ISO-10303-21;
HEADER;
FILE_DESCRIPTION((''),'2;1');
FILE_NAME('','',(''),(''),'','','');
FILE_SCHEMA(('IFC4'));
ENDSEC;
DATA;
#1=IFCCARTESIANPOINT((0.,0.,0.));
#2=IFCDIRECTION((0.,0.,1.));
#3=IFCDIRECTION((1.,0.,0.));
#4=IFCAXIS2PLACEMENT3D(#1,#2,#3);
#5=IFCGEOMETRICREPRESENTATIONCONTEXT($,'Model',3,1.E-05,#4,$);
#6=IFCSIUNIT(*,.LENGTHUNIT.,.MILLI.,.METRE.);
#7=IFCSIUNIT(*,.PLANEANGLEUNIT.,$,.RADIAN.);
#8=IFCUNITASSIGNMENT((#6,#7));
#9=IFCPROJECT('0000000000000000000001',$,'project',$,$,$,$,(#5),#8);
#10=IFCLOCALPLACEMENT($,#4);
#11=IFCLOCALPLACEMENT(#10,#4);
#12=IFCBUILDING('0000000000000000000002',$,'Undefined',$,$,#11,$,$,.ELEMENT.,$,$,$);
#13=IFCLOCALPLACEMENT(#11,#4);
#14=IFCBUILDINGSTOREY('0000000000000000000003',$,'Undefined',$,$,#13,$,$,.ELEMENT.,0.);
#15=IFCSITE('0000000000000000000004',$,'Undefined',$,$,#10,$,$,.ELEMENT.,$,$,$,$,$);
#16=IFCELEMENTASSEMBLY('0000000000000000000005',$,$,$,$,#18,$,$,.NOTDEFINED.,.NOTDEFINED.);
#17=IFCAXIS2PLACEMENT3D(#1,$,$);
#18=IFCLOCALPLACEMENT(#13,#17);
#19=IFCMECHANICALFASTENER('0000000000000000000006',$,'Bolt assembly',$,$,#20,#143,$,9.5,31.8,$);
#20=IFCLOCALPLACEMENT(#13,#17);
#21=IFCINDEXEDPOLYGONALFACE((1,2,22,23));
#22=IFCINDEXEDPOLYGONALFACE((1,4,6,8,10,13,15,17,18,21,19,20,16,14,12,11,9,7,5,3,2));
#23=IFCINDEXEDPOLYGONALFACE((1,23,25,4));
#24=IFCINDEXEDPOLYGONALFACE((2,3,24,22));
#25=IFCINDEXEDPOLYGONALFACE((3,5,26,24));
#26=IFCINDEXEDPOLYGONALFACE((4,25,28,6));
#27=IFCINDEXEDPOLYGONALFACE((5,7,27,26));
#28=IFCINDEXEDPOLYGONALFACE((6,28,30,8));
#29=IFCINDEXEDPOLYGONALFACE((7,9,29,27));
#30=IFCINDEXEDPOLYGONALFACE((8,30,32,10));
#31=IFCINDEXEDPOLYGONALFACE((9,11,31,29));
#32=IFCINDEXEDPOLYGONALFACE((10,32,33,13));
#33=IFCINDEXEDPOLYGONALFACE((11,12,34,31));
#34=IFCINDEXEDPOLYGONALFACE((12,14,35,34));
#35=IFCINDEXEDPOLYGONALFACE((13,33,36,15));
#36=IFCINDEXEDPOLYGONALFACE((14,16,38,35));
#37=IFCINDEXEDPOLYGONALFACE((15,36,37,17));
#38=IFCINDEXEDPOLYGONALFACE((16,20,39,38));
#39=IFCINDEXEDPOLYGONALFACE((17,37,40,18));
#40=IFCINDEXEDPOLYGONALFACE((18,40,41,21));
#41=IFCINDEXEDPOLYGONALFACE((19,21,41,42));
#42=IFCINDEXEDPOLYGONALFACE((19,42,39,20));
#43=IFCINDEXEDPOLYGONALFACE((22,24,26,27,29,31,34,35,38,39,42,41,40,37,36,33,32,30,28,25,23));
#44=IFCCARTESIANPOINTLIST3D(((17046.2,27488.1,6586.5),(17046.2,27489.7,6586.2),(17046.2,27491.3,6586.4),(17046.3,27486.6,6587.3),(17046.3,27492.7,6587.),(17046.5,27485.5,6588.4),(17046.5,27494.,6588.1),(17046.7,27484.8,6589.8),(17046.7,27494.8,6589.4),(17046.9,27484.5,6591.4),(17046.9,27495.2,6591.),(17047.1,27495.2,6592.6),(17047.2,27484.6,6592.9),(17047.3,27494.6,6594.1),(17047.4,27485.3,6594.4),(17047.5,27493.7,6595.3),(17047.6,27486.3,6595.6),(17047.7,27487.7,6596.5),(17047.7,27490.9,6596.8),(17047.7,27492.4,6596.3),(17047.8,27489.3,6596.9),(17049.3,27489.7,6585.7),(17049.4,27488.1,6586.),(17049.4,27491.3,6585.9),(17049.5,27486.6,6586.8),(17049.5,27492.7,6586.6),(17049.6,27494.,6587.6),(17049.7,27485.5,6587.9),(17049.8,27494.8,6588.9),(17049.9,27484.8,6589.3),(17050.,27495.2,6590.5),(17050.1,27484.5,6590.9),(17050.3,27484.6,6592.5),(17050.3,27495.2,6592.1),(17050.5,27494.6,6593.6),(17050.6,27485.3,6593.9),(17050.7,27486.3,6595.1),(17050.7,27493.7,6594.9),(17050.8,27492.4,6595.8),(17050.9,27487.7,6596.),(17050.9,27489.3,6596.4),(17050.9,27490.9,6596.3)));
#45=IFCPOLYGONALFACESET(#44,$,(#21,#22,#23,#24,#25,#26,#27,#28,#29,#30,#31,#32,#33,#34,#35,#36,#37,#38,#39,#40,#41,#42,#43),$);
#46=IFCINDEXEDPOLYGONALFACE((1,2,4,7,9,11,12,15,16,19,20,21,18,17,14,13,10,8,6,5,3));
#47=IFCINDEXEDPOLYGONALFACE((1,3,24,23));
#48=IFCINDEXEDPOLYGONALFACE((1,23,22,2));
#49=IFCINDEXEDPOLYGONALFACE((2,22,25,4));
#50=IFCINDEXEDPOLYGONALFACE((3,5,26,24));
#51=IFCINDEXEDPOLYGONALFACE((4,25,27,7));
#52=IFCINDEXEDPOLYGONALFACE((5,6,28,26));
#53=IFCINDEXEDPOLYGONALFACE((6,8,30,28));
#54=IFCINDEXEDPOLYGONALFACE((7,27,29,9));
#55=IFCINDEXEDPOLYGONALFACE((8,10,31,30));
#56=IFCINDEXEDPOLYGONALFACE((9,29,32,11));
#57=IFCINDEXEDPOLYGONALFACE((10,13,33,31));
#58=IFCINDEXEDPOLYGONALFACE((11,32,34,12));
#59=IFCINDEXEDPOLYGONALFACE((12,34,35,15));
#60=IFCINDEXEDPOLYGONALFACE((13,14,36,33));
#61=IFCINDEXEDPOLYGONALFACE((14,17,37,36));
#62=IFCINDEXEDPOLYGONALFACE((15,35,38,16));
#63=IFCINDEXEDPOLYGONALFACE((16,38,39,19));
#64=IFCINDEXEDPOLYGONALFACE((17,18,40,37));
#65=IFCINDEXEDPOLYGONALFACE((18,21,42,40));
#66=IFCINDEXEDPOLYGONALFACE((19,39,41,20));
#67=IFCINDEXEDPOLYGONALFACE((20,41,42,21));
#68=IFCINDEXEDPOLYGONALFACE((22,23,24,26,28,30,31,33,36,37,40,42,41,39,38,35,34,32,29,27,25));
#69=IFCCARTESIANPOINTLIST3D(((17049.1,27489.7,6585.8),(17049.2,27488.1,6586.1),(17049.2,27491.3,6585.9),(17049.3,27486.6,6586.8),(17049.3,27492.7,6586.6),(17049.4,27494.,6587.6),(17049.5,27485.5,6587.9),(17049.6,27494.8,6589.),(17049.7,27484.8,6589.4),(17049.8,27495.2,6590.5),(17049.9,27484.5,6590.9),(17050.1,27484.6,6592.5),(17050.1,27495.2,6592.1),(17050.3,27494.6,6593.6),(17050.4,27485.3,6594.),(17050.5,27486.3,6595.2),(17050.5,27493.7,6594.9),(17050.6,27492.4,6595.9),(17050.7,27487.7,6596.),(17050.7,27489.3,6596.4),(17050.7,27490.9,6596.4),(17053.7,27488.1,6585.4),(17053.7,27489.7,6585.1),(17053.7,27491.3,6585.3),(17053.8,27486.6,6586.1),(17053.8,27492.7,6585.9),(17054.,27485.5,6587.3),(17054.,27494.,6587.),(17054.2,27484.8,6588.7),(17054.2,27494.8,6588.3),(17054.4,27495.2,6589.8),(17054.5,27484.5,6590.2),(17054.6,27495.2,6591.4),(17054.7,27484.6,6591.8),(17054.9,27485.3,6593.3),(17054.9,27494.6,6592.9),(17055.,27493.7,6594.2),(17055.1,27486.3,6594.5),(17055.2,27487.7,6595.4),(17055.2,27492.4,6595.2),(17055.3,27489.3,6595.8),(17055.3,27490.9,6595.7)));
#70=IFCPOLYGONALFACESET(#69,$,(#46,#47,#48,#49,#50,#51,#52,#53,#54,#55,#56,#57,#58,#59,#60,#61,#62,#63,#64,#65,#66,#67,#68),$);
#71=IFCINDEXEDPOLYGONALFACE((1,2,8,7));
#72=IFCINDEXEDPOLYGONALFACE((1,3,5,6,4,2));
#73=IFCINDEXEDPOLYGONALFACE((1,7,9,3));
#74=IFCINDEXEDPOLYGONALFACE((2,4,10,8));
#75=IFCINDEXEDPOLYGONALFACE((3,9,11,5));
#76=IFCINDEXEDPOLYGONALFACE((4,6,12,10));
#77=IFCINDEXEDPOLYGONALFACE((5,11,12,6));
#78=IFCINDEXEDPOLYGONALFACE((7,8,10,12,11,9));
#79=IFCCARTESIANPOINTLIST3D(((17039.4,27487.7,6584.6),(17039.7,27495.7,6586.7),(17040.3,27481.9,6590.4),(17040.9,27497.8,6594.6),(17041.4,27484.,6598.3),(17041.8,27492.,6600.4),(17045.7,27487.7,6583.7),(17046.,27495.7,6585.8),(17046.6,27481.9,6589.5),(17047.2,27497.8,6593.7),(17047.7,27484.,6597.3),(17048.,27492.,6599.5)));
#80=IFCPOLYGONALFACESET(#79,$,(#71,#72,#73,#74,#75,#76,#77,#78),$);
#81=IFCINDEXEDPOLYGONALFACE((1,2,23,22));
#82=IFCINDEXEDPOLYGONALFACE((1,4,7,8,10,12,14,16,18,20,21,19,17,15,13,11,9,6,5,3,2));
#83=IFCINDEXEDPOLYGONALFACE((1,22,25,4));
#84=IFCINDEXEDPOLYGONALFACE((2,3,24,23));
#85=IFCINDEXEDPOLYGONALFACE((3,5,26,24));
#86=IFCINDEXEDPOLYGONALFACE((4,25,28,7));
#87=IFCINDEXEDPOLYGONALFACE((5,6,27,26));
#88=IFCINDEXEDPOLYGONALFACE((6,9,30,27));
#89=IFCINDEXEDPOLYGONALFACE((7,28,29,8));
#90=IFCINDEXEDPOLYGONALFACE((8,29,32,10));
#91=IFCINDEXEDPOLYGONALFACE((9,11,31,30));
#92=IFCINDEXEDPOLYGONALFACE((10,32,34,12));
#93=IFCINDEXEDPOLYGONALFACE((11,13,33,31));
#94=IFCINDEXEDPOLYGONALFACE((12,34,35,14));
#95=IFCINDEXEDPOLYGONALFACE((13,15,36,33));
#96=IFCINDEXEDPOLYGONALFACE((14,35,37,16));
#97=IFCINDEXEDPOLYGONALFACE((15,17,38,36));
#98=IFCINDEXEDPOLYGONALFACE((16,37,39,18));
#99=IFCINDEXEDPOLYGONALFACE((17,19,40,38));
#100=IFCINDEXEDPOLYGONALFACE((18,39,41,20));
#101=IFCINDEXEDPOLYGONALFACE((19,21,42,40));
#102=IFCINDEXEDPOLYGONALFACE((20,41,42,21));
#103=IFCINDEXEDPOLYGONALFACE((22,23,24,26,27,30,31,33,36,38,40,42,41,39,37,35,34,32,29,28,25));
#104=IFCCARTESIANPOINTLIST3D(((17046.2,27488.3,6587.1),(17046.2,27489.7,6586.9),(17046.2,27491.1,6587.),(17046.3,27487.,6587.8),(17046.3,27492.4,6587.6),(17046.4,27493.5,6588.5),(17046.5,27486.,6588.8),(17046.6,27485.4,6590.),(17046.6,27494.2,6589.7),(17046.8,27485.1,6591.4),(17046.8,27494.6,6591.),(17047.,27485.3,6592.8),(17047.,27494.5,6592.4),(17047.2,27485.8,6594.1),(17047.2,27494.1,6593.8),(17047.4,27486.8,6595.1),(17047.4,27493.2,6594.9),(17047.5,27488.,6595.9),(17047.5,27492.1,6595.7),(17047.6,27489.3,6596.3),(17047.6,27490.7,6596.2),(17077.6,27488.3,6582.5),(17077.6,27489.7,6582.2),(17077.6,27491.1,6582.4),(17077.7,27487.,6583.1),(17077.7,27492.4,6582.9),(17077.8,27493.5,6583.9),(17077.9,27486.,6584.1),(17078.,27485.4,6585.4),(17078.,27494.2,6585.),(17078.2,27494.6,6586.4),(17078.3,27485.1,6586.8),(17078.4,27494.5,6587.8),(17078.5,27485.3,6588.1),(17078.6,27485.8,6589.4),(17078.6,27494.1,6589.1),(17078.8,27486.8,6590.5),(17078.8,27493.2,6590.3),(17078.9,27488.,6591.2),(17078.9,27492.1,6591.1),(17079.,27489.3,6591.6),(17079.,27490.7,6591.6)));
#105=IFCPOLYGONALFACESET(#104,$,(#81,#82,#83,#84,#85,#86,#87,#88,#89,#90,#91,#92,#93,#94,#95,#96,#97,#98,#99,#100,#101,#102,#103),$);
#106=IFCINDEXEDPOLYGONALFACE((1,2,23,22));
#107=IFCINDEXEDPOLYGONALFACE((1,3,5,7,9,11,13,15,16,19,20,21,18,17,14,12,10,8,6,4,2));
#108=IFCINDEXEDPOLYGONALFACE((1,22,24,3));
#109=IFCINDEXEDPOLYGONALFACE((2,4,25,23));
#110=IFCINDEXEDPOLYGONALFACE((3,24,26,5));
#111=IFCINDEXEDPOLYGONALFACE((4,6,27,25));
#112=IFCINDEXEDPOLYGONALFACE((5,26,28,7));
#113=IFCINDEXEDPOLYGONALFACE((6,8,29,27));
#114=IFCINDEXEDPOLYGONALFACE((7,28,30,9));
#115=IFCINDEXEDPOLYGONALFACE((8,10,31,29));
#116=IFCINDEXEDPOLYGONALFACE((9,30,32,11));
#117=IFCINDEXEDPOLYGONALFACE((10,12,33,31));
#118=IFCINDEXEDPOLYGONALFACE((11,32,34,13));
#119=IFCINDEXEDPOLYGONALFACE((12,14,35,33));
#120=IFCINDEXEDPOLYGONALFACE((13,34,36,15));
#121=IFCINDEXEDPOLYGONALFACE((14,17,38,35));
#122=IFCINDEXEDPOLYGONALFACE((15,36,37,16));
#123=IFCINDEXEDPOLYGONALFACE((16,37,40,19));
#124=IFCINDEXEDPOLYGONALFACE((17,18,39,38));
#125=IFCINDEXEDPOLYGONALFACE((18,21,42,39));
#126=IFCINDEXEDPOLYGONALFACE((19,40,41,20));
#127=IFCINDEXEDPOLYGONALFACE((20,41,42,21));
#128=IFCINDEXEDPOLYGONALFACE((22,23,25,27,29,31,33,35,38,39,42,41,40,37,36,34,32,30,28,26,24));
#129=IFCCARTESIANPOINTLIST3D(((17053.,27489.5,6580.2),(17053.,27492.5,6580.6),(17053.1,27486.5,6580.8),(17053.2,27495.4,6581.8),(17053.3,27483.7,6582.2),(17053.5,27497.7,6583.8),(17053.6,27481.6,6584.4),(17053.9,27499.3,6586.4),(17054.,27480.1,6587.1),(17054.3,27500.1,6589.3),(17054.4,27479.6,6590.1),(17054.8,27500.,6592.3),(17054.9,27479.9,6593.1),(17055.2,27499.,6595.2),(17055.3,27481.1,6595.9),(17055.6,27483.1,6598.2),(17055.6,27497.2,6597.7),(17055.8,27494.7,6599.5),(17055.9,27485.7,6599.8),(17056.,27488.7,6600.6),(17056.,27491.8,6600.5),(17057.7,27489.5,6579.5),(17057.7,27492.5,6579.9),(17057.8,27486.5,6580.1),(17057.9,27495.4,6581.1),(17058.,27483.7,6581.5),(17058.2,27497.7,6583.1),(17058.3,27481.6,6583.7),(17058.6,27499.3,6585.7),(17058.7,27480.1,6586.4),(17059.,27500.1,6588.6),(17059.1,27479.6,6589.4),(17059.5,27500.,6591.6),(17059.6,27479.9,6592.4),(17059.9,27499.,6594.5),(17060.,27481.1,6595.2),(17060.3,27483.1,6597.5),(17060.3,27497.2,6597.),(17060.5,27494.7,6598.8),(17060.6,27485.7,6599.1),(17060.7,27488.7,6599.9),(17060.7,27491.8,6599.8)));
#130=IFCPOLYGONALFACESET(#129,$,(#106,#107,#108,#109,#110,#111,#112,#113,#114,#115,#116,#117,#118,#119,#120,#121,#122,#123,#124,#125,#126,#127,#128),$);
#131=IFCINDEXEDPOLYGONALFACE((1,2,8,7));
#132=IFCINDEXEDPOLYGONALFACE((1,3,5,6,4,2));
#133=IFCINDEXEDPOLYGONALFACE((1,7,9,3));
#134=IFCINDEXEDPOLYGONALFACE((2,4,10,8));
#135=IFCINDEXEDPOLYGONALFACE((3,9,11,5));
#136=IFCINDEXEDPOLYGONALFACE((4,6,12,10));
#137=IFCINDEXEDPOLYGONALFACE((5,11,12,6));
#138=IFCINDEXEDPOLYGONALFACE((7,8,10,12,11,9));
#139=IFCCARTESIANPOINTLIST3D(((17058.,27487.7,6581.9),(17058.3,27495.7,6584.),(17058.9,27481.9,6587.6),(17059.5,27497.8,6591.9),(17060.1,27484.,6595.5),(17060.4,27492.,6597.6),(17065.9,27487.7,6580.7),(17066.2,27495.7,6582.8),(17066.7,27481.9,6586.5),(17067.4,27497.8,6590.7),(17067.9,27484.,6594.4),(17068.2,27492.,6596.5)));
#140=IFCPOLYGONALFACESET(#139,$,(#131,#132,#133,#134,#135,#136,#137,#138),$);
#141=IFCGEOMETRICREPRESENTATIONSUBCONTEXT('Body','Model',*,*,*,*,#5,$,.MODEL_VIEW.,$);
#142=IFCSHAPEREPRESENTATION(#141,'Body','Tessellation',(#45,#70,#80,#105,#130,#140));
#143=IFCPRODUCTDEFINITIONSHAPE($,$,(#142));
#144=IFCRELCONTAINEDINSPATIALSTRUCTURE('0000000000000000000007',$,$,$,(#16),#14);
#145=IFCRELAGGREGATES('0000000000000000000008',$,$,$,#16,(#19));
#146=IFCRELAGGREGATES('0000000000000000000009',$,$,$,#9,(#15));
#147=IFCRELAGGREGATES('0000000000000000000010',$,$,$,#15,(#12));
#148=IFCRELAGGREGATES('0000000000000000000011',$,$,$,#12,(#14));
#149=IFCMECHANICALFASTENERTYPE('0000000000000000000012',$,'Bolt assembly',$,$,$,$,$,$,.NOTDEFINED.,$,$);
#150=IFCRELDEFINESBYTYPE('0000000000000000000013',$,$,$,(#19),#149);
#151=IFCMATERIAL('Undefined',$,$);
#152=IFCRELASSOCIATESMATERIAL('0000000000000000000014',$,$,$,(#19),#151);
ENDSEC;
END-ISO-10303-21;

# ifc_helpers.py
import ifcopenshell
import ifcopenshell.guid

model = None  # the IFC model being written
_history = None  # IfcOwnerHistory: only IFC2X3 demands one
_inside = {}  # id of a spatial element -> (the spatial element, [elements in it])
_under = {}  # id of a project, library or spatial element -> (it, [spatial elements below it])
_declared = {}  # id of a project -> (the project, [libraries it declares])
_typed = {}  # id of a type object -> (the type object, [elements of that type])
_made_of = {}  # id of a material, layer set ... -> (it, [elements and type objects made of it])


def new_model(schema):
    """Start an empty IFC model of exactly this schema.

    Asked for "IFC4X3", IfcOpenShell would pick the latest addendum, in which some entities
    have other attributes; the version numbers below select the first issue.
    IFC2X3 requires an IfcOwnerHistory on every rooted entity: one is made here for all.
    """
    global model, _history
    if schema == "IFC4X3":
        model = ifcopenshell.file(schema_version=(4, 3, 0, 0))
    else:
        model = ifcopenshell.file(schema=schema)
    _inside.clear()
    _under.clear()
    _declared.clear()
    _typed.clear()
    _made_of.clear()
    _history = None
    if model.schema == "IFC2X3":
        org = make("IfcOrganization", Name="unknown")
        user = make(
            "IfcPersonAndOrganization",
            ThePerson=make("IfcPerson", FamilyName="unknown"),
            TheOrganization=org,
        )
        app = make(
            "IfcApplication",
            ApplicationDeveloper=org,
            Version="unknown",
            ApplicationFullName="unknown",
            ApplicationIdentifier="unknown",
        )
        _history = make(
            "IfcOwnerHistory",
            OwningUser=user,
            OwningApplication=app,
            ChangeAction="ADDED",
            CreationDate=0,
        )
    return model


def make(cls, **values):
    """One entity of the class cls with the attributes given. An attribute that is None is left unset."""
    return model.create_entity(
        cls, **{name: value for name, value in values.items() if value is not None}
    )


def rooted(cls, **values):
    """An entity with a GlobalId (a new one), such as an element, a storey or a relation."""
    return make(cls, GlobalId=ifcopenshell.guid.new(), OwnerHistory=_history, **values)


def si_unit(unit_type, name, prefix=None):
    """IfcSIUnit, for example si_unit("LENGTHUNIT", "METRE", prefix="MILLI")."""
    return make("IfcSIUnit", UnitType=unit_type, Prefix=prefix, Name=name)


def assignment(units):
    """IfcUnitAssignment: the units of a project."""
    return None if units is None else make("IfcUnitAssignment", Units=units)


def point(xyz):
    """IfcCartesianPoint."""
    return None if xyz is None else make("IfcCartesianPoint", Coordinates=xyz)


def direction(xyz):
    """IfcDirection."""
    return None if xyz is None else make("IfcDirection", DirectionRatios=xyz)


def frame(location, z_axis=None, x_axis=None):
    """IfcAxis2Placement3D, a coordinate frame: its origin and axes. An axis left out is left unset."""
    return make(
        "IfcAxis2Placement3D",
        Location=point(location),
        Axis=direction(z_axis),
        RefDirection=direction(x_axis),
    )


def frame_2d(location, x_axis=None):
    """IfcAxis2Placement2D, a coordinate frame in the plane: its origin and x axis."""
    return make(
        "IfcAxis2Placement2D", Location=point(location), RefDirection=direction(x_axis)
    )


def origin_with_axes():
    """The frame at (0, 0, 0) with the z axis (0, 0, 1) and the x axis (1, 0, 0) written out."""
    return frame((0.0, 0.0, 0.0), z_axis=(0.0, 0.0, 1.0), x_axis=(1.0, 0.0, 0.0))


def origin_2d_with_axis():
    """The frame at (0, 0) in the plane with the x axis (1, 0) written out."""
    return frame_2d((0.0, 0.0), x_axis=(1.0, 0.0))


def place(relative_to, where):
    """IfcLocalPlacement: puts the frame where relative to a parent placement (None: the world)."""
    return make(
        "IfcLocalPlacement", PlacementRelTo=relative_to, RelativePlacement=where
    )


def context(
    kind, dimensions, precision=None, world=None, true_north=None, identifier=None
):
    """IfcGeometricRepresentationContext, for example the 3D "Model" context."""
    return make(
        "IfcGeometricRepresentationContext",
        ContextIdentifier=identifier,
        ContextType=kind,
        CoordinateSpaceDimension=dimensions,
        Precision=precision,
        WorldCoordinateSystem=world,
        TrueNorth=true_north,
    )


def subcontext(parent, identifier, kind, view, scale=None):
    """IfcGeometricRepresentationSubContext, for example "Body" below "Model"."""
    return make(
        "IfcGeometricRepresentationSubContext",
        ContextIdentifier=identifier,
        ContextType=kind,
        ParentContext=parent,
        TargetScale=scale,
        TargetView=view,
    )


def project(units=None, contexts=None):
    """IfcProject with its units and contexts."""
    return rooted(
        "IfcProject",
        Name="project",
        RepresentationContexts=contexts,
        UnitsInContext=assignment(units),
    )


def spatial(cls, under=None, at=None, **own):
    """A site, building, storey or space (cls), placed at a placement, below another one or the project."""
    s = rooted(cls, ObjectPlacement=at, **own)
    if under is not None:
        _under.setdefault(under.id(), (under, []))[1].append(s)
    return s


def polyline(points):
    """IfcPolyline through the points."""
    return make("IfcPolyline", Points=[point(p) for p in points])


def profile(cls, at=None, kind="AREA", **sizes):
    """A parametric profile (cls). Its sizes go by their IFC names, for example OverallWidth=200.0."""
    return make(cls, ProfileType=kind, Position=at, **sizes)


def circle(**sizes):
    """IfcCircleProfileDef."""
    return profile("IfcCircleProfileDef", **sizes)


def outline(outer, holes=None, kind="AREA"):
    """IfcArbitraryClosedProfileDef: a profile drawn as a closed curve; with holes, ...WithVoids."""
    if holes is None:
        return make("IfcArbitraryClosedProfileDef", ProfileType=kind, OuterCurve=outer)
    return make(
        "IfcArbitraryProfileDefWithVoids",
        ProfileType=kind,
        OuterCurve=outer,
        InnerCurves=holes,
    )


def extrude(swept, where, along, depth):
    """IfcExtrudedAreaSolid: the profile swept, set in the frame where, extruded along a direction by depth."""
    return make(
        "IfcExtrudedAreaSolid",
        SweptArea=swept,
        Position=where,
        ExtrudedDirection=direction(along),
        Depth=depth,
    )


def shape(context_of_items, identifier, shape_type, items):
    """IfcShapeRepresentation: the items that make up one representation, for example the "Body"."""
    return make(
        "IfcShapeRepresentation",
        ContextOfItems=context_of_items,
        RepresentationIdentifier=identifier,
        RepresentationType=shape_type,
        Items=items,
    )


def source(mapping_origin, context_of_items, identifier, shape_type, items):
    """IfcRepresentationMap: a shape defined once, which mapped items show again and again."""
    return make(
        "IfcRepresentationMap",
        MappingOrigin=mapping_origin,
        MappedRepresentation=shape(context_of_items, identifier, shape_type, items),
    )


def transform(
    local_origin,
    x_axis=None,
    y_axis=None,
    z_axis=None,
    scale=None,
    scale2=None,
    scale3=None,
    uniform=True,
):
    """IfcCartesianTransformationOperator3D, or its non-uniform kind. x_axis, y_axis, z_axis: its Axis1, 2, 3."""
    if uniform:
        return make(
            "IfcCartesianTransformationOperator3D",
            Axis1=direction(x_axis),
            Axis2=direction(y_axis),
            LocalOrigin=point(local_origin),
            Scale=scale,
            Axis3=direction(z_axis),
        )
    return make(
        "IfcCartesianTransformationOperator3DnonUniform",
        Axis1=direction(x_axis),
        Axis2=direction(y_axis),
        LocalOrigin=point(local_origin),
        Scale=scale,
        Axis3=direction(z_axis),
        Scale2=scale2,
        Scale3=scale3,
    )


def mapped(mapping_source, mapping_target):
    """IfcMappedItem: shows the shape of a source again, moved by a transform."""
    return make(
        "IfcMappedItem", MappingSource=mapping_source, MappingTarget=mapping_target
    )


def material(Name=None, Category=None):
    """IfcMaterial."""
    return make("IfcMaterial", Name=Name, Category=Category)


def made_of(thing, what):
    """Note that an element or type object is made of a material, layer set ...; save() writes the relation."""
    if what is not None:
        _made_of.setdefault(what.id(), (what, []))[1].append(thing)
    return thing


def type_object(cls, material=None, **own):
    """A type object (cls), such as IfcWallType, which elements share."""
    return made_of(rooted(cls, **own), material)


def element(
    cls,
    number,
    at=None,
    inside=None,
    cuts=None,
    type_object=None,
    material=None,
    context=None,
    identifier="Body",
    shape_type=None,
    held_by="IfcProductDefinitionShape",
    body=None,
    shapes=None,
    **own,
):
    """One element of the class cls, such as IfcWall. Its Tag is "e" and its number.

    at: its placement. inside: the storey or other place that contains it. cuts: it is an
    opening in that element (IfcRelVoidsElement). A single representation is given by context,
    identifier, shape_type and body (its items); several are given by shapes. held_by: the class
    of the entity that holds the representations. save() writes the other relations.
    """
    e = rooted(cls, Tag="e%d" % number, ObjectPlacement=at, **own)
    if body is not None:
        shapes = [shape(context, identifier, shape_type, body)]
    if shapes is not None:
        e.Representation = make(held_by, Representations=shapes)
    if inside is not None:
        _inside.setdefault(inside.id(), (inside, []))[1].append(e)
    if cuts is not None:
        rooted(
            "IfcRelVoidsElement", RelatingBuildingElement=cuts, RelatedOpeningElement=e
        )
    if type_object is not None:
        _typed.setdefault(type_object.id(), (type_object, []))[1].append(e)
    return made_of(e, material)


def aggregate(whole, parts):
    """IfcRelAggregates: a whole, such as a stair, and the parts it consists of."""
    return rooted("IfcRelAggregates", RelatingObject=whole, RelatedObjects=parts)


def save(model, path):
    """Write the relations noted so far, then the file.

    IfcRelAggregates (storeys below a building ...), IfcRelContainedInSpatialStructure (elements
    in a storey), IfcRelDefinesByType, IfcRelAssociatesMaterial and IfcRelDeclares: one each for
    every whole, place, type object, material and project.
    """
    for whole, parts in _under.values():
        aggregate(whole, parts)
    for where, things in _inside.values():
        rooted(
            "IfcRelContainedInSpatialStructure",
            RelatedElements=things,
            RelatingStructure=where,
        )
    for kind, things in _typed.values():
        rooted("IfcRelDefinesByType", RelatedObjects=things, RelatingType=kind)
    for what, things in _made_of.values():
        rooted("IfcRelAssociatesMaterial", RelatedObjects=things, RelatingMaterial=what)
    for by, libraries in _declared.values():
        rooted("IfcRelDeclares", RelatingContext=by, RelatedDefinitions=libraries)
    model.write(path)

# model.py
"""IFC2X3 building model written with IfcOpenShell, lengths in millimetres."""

from ifc_helpers import new_model, si_unit, frame, origin_with_axes, origin_2d_with_axis, place, context, subcontext, project, spatial, polyline, circle, outline, extrude, source, transform, mapped, material, type_object, element, aggregate, save


model = new_model("IFC2X3")

# Units and contexts
model_context = context("Model", 3, precision=1e-05, world=origin_with_axes())
body_context = subcontext(model_context, "Body", "Model", "MODEL_VIEW")
ifc_project = project(units=[si_unit("LENGTHUNIT", "METRE", prefix="MILLI"), si_unit("PLANEANGLEUNIT", "RADIAN")], contexts=[model_context])

# Site, building, storey
site_placement = place(None, origin_with_axes())
site = spatial("IfcSite", under=ifc_project, at=site_placement, Name="Undefined", CompositionType="ELEMENT")
building_placement = place(site_placement, origin_with_axes())
building = spatial("IfcBuilding", under=site, at=building_placement, Name="Undefined", CompositionType="ELEMENT")
storey_placement = place(building_placement, origin_with_axes())
storey = spatial("IfcBuildingStorey", under=building, at=storey_placement, Name="Undefined", CompositionType="ELEMENT", Elevation=0.0)

# Element assembly
assembly_1_placement = place(storey_placement, origin_with_axes())
assembly_1 = element("IfcElementAssembly", 1, at=assembly_1_placement, inside=storey, AssemblyPlace="NOTDEFINED", PredefinedType="NOTDEFINED")

# Shared definitions
ifc_material_1 = material(Name="Undefined")
mechanical_fastener_type = type_object("IfcMechanicalFastenerType", Name="Bolt assembly")

# Mechanical fastener
shared_shape_1 = source(origin_with_axes(), body_context, "Body", "SweptSolid", [
    extrude(circle(Radius=5.4, at=origin_2d_with_axis()), frame((0.0, -3.1, 0.0), z_axis=(0.0, 1.0, 0.0), x_axis=(1.0, 0.0, 0.0)), (0.0, 0.0, 1.0), 3.2),
    extrude(circle(Radius=5.4, at=origin_2d_with_axis()), frame((0.0, -0.1, 0.0), z_axis=(0.0, 1.0, 0.0), x_axis=(1.0, 0.0, 0.0)), (0.0, 0.0, 1.0), 4.6),
    extrude(outline(polyline([(7.1, -4.1), (7.1, 4.1), (0.0, 8.2), (-7.1, 4.1), (-7.1, -4.1), (0.0, -8.2), (7.1, -4.1)])), frame((0.0, -9.6, 0.0), z_axis=(0.0, 1.0, 0.0), x_axis=(1.0, 0.0, 0.0)), (0.0, 0.0, 1.0), 6.3),
    extrude(circle(Radius=4.8, at=origin_2d_with_axis()), frame((0.0, -3.2, 0.0), z_axis=(0.0, 1.0, 0.0), x_axis=(1.0, 0.0, 0.0)), (0.0, 0.0, 1.0), 31.8),
    extrude(circle(Radius=10.3, at=origin_2d_with_axis()), frame((0.0, 4.5, 0.0), z_axis=(0.0, 1.0, 0.0), x_axis=(1.0, 0.0, 0.0)), (0.0, 0.0, 1.0), 4.8),
    extrude(outline(polyline([(7.1, -4.1), (7.1, 4.1), (0.0, 8.2), (-7.1, 4.1), (-7.1, -4.1), (0.0, -8.2), (7.1, -4.1)])), frame((0.0, 9.3, 0.0), z_axis=(0.0, 1.0, 0.0), x_axis=(1.0, 0.0, 0.0)), (0.0, 0.0, 1.0), 7.9),
])
mechanical_fastener_1_placement = place(assembly_1_placement, frame((17050.0, 27489.9, 6591.1), z_axis=(-0.10338, 0.707107, -0.699509), x_axis=(0.10338, 0.707107, 0.699509)))
mechanical_fastener_1 = element("IfcMechanicalFastener", 2, at=mechanical_fastener_1_placement, type_object=mechanical_fastener_type, material=ifc_material_1, Name="Bolt assembly", NominalDiameter=9.5, NominalLength=31.8, context=body_context, shape_type="MappedRepresentation", body=[
    mapped(shared_shape_1, transform((0.0, 0.0, 0.0))),
])
aggregate(assembly_1, [mechanical_fastener_1])

save(model, "model.ifc")
